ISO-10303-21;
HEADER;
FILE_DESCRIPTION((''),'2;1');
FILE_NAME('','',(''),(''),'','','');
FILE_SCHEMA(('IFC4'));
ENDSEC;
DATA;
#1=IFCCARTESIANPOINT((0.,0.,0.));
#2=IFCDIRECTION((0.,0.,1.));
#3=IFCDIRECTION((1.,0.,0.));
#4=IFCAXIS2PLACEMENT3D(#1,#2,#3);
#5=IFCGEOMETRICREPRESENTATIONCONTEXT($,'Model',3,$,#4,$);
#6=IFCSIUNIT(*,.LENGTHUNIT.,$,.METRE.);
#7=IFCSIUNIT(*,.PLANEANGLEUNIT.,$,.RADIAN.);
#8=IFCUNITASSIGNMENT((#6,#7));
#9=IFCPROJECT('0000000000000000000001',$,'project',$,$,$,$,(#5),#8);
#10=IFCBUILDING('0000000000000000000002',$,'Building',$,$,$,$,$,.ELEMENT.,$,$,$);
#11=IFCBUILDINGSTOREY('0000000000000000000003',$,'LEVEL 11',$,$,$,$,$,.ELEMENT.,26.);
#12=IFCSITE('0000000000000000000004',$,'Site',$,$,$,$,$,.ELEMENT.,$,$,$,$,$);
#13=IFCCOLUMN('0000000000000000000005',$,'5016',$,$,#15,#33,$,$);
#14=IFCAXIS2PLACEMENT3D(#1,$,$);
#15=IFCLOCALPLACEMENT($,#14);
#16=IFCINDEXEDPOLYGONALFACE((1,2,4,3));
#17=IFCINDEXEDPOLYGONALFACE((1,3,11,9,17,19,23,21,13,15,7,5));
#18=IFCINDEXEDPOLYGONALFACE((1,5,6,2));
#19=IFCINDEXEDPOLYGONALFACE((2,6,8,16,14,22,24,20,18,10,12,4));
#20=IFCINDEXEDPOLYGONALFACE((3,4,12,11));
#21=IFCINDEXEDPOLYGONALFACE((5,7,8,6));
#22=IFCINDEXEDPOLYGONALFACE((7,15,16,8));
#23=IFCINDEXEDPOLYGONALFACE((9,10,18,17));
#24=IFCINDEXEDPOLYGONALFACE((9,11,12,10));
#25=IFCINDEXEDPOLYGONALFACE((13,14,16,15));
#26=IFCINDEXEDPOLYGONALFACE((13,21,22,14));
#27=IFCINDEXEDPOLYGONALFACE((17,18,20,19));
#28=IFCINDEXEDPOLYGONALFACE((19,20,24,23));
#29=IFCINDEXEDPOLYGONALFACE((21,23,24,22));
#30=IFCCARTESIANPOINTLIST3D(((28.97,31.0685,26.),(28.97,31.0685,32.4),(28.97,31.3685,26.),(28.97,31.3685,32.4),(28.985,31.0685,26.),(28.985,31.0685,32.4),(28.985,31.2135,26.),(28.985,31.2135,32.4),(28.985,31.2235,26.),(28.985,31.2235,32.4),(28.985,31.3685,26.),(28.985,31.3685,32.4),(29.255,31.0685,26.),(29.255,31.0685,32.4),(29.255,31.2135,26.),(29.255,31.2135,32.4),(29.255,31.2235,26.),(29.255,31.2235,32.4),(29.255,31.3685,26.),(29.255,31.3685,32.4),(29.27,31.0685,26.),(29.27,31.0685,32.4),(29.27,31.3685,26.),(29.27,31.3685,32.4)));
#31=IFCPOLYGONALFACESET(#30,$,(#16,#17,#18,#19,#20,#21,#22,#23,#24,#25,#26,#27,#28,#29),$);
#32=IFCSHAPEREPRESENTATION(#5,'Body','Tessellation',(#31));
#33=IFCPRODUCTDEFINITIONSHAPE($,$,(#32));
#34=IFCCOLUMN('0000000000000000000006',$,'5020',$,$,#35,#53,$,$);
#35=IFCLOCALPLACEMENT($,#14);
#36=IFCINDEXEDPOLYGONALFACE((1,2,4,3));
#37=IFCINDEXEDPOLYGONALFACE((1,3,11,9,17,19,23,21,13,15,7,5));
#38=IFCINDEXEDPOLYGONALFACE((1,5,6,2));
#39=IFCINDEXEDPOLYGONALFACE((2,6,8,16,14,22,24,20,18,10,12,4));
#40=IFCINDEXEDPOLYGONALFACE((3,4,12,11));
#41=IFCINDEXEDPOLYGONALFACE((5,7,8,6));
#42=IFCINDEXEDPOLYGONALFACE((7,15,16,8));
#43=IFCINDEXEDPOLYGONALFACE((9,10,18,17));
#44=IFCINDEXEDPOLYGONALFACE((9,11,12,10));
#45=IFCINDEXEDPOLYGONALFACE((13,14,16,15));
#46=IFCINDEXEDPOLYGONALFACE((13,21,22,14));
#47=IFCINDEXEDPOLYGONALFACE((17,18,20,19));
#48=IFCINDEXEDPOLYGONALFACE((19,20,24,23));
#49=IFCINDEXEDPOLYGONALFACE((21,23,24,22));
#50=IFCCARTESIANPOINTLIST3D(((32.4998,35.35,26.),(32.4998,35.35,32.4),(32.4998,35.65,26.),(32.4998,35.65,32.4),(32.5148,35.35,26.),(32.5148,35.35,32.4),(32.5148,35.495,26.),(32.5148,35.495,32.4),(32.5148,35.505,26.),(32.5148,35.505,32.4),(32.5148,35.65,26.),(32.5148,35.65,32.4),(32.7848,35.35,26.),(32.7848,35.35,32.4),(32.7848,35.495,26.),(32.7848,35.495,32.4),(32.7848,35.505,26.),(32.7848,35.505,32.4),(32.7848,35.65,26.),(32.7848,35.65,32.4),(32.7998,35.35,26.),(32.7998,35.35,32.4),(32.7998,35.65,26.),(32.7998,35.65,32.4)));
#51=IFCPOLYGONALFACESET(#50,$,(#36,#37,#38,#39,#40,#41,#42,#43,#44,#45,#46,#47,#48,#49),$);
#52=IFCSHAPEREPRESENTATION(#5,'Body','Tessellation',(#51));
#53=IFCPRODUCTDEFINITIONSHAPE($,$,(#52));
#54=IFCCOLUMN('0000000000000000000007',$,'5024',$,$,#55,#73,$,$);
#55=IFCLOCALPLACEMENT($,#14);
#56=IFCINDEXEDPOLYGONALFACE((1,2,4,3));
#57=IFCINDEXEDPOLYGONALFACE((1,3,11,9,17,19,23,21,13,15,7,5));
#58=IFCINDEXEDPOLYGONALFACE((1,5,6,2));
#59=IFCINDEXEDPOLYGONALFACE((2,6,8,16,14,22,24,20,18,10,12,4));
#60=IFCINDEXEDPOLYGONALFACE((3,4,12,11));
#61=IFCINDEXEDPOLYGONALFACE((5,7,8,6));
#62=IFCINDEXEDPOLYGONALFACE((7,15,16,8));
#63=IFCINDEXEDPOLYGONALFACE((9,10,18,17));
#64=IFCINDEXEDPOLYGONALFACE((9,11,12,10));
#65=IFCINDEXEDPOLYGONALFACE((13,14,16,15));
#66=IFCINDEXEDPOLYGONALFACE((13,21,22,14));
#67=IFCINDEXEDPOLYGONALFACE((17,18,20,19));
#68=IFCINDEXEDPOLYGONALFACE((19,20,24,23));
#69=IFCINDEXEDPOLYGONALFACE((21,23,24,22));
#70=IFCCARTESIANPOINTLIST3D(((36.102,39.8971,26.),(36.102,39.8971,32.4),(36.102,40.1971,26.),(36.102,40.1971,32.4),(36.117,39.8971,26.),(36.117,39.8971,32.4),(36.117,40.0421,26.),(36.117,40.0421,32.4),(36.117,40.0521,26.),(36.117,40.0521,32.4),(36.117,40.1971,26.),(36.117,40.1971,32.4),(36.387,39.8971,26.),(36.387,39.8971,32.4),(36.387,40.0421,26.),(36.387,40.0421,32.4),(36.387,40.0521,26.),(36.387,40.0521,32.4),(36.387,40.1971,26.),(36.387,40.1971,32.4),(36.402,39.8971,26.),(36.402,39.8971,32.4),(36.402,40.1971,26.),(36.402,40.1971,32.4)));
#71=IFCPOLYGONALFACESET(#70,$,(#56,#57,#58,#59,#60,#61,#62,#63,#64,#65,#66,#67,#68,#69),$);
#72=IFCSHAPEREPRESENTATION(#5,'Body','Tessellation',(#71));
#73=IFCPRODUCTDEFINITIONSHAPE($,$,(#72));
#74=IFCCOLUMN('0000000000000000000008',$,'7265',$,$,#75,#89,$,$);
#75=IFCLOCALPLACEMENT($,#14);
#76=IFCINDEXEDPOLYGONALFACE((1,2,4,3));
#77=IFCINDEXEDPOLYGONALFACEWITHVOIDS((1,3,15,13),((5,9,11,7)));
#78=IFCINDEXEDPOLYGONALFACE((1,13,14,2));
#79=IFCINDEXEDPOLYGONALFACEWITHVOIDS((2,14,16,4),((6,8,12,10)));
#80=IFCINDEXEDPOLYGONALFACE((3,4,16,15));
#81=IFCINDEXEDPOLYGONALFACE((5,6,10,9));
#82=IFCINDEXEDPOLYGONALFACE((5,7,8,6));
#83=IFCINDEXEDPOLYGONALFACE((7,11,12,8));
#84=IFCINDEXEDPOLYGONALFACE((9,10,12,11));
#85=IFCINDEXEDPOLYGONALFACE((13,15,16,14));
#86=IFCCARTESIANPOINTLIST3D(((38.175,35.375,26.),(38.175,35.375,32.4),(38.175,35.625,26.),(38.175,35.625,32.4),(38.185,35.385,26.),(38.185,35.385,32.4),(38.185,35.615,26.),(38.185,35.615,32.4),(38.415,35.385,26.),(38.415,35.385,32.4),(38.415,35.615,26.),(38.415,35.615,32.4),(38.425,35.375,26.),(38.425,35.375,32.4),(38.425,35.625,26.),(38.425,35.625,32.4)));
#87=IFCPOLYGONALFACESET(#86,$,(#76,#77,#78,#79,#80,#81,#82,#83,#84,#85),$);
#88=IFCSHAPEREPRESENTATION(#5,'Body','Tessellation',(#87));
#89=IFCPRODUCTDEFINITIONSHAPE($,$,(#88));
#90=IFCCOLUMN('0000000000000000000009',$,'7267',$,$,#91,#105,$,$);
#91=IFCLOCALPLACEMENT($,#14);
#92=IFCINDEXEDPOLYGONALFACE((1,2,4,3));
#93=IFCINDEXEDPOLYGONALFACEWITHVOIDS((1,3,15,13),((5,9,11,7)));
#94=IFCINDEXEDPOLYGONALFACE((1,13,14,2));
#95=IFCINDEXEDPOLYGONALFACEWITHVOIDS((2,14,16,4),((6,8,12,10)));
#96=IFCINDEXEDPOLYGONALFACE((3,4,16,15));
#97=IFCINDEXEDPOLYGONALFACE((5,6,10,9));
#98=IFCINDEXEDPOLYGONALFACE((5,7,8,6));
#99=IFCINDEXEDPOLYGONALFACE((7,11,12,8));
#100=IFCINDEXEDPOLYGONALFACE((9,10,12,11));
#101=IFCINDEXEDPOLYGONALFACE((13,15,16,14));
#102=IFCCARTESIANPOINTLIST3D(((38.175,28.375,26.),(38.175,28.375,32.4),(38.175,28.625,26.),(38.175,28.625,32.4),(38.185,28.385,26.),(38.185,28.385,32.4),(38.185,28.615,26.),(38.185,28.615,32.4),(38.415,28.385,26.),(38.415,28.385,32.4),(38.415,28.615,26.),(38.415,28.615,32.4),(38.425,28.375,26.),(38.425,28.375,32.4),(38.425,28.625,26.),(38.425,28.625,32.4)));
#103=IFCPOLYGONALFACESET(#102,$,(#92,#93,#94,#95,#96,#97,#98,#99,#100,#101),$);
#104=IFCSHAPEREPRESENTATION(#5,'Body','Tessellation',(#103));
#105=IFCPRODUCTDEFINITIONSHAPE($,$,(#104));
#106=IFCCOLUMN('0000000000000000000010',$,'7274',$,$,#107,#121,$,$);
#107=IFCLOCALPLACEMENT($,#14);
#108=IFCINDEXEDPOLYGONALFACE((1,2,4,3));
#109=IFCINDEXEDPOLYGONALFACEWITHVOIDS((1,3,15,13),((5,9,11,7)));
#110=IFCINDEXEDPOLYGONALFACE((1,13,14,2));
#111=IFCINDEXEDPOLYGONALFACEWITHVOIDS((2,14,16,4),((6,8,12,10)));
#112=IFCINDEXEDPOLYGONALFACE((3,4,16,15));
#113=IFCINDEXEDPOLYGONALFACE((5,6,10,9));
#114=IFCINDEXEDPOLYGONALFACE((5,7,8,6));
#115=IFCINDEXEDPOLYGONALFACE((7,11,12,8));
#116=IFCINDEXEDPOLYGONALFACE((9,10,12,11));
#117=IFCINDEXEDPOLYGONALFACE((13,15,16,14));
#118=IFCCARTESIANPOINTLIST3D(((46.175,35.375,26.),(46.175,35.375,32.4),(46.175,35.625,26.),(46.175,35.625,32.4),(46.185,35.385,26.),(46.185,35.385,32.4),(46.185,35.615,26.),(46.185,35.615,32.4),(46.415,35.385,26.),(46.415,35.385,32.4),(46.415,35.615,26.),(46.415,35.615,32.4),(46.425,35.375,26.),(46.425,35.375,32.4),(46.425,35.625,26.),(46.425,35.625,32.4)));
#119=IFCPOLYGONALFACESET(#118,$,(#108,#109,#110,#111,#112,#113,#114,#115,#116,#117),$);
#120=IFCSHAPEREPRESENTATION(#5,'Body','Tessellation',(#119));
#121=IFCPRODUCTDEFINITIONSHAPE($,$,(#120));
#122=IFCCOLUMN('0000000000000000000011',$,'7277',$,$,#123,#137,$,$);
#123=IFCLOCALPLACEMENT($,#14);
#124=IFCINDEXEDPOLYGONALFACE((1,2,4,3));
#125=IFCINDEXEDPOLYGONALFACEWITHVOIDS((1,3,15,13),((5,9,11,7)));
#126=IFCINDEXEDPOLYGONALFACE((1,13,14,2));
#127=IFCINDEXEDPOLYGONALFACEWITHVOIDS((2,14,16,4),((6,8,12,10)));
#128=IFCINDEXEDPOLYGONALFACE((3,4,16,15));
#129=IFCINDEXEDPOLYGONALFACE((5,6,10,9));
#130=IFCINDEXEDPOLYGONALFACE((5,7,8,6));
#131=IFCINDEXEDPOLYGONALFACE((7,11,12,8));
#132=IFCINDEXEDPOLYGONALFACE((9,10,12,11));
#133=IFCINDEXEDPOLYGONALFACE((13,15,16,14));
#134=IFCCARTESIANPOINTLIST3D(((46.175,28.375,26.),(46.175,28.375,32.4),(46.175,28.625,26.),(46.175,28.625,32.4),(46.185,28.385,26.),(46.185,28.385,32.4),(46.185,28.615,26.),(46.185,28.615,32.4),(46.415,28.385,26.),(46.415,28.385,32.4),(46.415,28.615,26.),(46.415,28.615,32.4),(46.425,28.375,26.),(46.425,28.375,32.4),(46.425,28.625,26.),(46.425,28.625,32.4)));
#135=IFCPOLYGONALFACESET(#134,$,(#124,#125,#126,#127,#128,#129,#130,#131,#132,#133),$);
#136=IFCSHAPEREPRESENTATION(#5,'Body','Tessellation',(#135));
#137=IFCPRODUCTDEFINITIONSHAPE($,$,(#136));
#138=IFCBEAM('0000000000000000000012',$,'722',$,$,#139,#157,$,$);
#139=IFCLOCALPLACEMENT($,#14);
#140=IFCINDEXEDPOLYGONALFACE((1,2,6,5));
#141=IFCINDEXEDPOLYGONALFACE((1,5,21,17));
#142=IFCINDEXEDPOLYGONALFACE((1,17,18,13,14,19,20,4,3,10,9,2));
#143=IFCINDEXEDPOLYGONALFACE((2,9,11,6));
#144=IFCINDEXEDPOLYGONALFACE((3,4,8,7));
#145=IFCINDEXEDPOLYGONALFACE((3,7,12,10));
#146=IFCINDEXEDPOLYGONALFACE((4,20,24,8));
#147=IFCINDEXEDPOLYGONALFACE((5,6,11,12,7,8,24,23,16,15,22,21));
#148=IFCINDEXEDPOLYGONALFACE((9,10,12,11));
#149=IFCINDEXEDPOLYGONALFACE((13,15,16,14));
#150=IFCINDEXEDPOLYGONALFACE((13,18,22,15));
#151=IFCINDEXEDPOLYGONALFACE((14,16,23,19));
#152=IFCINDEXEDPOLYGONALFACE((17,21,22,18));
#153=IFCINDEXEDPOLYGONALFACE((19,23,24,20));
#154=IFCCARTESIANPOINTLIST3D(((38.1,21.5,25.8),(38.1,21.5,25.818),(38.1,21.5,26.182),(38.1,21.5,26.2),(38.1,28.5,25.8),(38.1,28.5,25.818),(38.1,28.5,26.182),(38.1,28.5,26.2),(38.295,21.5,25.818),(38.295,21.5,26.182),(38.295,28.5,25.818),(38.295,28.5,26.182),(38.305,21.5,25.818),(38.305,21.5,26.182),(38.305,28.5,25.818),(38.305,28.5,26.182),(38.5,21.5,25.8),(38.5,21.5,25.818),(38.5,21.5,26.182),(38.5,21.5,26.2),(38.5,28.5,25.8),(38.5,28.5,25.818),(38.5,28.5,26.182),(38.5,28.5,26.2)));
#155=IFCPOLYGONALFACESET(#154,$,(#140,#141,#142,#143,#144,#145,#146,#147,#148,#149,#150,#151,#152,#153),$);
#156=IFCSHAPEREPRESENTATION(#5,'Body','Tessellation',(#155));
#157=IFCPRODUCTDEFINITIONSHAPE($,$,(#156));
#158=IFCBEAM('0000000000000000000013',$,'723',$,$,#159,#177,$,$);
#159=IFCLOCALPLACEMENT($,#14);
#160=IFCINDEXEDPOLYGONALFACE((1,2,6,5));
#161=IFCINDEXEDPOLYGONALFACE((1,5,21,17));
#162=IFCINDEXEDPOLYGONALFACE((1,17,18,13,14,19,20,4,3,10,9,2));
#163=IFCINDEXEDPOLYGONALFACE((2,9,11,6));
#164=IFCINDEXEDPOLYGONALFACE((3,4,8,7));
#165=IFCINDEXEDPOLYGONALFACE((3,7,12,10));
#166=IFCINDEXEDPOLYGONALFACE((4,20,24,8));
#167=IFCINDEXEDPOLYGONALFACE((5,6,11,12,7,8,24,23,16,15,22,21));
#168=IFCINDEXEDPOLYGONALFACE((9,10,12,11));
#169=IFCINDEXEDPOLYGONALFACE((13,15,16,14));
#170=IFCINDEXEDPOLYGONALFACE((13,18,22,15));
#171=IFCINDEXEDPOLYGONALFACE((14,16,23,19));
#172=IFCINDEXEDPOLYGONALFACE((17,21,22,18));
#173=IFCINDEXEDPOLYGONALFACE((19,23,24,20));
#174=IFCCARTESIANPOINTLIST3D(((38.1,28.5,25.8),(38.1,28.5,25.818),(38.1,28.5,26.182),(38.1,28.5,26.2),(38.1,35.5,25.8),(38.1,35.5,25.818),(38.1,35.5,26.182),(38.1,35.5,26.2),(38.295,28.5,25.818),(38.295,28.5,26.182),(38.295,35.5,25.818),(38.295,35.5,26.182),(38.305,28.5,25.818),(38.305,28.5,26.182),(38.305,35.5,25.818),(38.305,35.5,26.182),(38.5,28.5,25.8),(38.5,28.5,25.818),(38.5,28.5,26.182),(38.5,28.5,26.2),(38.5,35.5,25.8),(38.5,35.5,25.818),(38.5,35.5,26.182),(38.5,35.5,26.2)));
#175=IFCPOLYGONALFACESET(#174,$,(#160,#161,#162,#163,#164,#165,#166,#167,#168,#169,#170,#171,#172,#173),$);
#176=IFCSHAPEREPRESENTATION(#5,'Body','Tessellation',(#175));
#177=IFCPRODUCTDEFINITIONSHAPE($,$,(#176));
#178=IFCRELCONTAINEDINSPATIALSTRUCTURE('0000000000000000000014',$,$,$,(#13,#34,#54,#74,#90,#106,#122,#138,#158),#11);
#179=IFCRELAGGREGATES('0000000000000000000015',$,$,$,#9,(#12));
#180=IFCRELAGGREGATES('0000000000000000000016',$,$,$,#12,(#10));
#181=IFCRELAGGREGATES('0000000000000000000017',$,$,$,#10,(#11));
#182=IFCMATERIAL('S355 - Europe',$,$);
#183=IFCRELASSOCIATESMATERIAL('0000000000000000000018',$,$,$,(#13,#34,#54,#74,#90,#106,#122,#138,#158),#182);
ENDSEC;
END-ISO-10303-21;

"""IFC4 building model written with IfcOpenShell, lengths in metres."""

from ifc_helpers import new_model, si_unit, frame, origin_with_axes, origin_2d_with_axis, place, context, project, spatial, hollow_rectangle, i_section, extrude, material, material_profile, profile_set, profile_usage, element, save


model = new_model("IFC4")

# Units and contexts
model_context = context("Model", 3, world=origin_with_axes())
ifc_project = project(units=[si_unit("LENGTHUNIT", "METRE"), si_unit("PLANEANGLEUNIT", "RADIAN")], contexts=[model_context])

# Site, building, storey
site = spatial("IfcSite", under=ifc_project, Name="Site", CompositionType="ELEMENT")
building = spatial("IfcBuilding", under=site, Name="Building", CompositionType="ELEMENT")
storey = spatial("IfcBuildingStorey", under=building, Name="LEVEL 11", CompositionType="ELEMENT", Elevation=26.0)

# Columns
ifc_material = material(Name="S355 - Europe")
ifc_material_profile_1 = material_profile(ifc_material, i_section(OverallWidth=0.3, OverallDepth=0.3, WebThickness=0.01, FlangeThickness=0.015, at=origin_2d_with_axis()))
ifc_profile_set_1 = profile_set([ifc_material_profile_1])
ifc_profile_usage_1 = profile_usage(ifc_profile_set_1, cardinal=10)
column_1_placement = place(None, frame((29.12, 31.2185, 26.0), z_axis=(0.0, 0.0, 1.0), x_axis=(0.0, -1.0, 0.0)))
element("IfcColumn", 1, at=column_1_placement, inside=storey, material=ifc_profile_usage_1, Name="5016", context=model_context, shape_type="SweptSolid", body=[
    extrude(i_section(OverallWidth=0.3, OverallDepth=0.3, WebThickness=0.01, FlangeThickness=0.015, at=origin_2d_with_axis()), origin_with_axes(), (0.0, 0.0, 1.0), 6.4),
])
ifc_material_profile_2 = material_profile(ifc_material, i_section(OverallWidth=0.3, OverallDepth=0.3, WebThickness=0.01, FlangeThickness=0.015, at=origin_2d_with_axis()))
ifc_profile_set_2 = profile_set([ifc_material_profile_2])
ifc_profile_usage_2 = profile_usage(ifc_profile_set_2, cardinal=10)
column_2_placement = place(None, frame((32.6498, 35.5, 26.0), z_axis=(0.0, 0.0, 1.0), x_axis=(0.0, -1.0, 0.0)))
element("IfcColumn", 2, at=column_2_placement, inside=storey, material=ifc_profile_usage_2, Name="5020", context=model_context, shape_type="SweptSolid", body=[
    extrude(i_section(OverallWidth=0.3, OverallDepth=0.3, WebThickness=0.01, FlangeThickness=0.015, at=origin_2d_with_axis()), origin_with_axes(), (0.0, 0.0, 1.0), 6.4),
])
ifc_material_profile_3 = material_profile(ifc_material, i_section(OverallWidth=0.3, OverallDepth=0.3, WebThickness=0.01, FlangeThickness=0.015, at=origin_2d_with_axis()))
ifc_profile_set_3 = profile_set([ifc_material_profile_3])
ifc_profile_usage_3 = profile_usage(ifc_profile_set_3, cardinal=10)
column_3_placement = place(None, frame((36.252, 40.0471, 26.0), z_axis=(0.0, 0.0, 1.0), x_axis=(0.0, -1.0, 0.0)))
element("IfcColumn", 3, at=column_3_placement, inside=storey, material=ifc_profile_usage_3, Name="5024", context=model_context, shape_type="SweptSolid", body=[
    extrude(i_section(OverallWidth=0.3, OverallDepth=0.3, WebThickness=0.01, FlangeThickness=0.015, at=origin_2d_with_axis()), origin_with_axes(), (0.0, 0.0, 1.0), 6.4),
])
ifc_material_profile_4 = material_profile(ifc_material, hollow_rectangle(XDim=0.25, YDim=0.25, WallThickness=0.01, at=origin_2d_with_axis()))
ifc_profile_set_4 = profile_set([ifc_material_profile_4])
ifc_profile_usage_4 = profile_usage(ifc_profile_set_4, cardinal=10)
column_4_placement = place(None, frame((38.3, 35.5, 26.0), z_axis=(0.0, 0.0, 1.0), x_axis=(0.0, -1.0, 0.0)))
element("IfcColumn", 4, at=column_4_placement, inside=storey, material=ifc_profile_usage_4, Name="7265", context=model_context, shape_type="SweptSolid", body=[
    extrude(hollow_rectangle(XDim=0.25, YDim=0.25, WallThickness=0.01, at=origin_2d_with_axis()), origin_with_axes(), (0.0, 0.0, 1.0), 6.4),
])
ifc_material_profile_5 = material_profile(ifc_material, hollow_rectangle(XDim=0.25, YDim=0.25, WallThickness=0.01, at=origin_2d_with_axis()))
ifc_profile_set_5 = profile_set([ifc_material_profile_5])
ifc_profile_usage_5 = profile_usage(ifc_profile_set_5, cardinal=10)
column_5_placement = place(None, frame((38.3, 28.5, 26.0), z_axis=(0.0, 0.0, 1.0), x_axis=(0.0, -1.0, 0.0)))
element("IfcColumn", 5, at=column_5_placement, inside=storey, material=ifc_profile_usage_5, Name="7267", context=model_context, shape_type="SweptSolid", body=[
    extrude(hollow_rectangle(XDim=0.25, YDim=0.25, WallThickness=0.01, at=origin_2d_with_axis()), origin_with_axes(), (0.0, 0.0, 1.0), 6.4),
])
ifc_material_profile_6 = material_profile(ifc_material, hollow_rectangle(XDim=0.25, YDim=0.25, WallThickness=0.01, at=origin_2d_with_axis()))
ifc_profile_set_6 = profile_set([ifc_material_profile_6])
ifc_profile_usage_6 = profile_usage(ifc_profile_set_6, cardinal=10)
column_6_placement = place(None, frame((46.3, 35.5, 26.0), z_axis=(0.0, 0.0, 1.0), x_axis=(0.0, -1.0, 0.0)))
element("IfcColumn", 6, at=column_6_placement, inside=storey, material=ifc_profile_usage_6, Name="7274", context=model_context, shape_type="SweptSolid", body=[
    extrude(hollow_rectangle(XDim=0.25, YDim=0.25, WallThickness=0.01, at=origin_2d_with_axis()), origin_with_axes(), (0.0, 0.0, 1.0), 6.4),
])
ifc_material_profile_7 = material_profile(ifc_material, hollow_rectangle(XDim=0.25, YDim=0.25, WallThickness=0.01, at=origin_2d_with_axis()))
ifc_profile_set_7 = profile_set([ifc_material_profile_7])
ifc_profile_usage_7 = profile_usage(ifc_profile_set_7, cardinal=10)
column_7_placement = place(None, frame((46.3, 28.5, 26.0), z_axis=(0.0, 0.0, 1.0), x_axis=(0.0, -1.0, 0.0)))
element("IfcColumn", 7, at=column_7_placement, inside=storey, material=ifc_profile_usage_7, Name="7277", context=model_context, shape_type="SweptSolid", body=[
    extrude(hollow_rectangle(XDim=0.25, YDim=0.25, WallThickness=0.01, at=origin_2d_with_axis()), origin_with_axes(), (0.0, 0.0, 1.0), 6.4),
])

# Beams
ifc_material_profile_8 = material_profile(ifc_material, i_section(OverallWidth=0.4, OverallDepth=0.4, WebThickness=0.01, FlangeThickness=0.018, at=origin_2d_with_axis()))
ifc_profile_set_8 = profile_set([ifc_material_profile_8])
ifc_profile_usage_8 = profile_usage(ifc_profile_set_8, cardinal=10)
beam_1_placement = place(None, frame((38.3, 28.5, 26.0), z_axis=(0.0, -1.0, 0.0), x_axis=(1.0, 0.0, 0.0)))
element("IfcBeam", 8, at=beam_1_placement, inside=storey, material=ifc_profile_usage_8, Name="722", context=model_context, shape_type="SweptSolid", body=[
    extrude(i_section(OverallWidth=0.4, OverallDepth=0.4, WebThickness=0.01, FlangeThickness=0.018, at=origin_2d_with_axis()), origin_with_axes(), (0.0, 0.0, 1.0), 7.0),
])
ifc_material_profile_9 = material_profile(ifc_material, i_section(OverallWidth=0.4, OverallDepth=0.4, WebThickness=0.01, FlangeThickness=0.018, at=origin_2d_with_axis()))
ifc_profile_set_9 = profile_set([ifc_material_profile_9])
ifc_profile_usage_9 = profile_usage(ifc_profile_set_9, cardinal=10)
beam_2_placement = place(None, frame((38.3, 35.5, 26.0), z_axis=(0.0, -1.0, 0.0), x_axis=(1.0, 0.0, 0.0)))
element("IfcBeam", 9, at=beam_2_placement, inside=storey, material=ifc_profile_usage_9, Name="723", context=model_context, shape_type="SweptSolid", body=[
    extrude(i_section(OverallWidth=0.4, OverallDepth=0.4, WebThickness=0.01, FlangeThickness=0.018, at=origin_2d_with_axis()), origin_with_axes(), (0.0, 0.0, 1.0), 7.0),
])

save(model, "model.ifc")
